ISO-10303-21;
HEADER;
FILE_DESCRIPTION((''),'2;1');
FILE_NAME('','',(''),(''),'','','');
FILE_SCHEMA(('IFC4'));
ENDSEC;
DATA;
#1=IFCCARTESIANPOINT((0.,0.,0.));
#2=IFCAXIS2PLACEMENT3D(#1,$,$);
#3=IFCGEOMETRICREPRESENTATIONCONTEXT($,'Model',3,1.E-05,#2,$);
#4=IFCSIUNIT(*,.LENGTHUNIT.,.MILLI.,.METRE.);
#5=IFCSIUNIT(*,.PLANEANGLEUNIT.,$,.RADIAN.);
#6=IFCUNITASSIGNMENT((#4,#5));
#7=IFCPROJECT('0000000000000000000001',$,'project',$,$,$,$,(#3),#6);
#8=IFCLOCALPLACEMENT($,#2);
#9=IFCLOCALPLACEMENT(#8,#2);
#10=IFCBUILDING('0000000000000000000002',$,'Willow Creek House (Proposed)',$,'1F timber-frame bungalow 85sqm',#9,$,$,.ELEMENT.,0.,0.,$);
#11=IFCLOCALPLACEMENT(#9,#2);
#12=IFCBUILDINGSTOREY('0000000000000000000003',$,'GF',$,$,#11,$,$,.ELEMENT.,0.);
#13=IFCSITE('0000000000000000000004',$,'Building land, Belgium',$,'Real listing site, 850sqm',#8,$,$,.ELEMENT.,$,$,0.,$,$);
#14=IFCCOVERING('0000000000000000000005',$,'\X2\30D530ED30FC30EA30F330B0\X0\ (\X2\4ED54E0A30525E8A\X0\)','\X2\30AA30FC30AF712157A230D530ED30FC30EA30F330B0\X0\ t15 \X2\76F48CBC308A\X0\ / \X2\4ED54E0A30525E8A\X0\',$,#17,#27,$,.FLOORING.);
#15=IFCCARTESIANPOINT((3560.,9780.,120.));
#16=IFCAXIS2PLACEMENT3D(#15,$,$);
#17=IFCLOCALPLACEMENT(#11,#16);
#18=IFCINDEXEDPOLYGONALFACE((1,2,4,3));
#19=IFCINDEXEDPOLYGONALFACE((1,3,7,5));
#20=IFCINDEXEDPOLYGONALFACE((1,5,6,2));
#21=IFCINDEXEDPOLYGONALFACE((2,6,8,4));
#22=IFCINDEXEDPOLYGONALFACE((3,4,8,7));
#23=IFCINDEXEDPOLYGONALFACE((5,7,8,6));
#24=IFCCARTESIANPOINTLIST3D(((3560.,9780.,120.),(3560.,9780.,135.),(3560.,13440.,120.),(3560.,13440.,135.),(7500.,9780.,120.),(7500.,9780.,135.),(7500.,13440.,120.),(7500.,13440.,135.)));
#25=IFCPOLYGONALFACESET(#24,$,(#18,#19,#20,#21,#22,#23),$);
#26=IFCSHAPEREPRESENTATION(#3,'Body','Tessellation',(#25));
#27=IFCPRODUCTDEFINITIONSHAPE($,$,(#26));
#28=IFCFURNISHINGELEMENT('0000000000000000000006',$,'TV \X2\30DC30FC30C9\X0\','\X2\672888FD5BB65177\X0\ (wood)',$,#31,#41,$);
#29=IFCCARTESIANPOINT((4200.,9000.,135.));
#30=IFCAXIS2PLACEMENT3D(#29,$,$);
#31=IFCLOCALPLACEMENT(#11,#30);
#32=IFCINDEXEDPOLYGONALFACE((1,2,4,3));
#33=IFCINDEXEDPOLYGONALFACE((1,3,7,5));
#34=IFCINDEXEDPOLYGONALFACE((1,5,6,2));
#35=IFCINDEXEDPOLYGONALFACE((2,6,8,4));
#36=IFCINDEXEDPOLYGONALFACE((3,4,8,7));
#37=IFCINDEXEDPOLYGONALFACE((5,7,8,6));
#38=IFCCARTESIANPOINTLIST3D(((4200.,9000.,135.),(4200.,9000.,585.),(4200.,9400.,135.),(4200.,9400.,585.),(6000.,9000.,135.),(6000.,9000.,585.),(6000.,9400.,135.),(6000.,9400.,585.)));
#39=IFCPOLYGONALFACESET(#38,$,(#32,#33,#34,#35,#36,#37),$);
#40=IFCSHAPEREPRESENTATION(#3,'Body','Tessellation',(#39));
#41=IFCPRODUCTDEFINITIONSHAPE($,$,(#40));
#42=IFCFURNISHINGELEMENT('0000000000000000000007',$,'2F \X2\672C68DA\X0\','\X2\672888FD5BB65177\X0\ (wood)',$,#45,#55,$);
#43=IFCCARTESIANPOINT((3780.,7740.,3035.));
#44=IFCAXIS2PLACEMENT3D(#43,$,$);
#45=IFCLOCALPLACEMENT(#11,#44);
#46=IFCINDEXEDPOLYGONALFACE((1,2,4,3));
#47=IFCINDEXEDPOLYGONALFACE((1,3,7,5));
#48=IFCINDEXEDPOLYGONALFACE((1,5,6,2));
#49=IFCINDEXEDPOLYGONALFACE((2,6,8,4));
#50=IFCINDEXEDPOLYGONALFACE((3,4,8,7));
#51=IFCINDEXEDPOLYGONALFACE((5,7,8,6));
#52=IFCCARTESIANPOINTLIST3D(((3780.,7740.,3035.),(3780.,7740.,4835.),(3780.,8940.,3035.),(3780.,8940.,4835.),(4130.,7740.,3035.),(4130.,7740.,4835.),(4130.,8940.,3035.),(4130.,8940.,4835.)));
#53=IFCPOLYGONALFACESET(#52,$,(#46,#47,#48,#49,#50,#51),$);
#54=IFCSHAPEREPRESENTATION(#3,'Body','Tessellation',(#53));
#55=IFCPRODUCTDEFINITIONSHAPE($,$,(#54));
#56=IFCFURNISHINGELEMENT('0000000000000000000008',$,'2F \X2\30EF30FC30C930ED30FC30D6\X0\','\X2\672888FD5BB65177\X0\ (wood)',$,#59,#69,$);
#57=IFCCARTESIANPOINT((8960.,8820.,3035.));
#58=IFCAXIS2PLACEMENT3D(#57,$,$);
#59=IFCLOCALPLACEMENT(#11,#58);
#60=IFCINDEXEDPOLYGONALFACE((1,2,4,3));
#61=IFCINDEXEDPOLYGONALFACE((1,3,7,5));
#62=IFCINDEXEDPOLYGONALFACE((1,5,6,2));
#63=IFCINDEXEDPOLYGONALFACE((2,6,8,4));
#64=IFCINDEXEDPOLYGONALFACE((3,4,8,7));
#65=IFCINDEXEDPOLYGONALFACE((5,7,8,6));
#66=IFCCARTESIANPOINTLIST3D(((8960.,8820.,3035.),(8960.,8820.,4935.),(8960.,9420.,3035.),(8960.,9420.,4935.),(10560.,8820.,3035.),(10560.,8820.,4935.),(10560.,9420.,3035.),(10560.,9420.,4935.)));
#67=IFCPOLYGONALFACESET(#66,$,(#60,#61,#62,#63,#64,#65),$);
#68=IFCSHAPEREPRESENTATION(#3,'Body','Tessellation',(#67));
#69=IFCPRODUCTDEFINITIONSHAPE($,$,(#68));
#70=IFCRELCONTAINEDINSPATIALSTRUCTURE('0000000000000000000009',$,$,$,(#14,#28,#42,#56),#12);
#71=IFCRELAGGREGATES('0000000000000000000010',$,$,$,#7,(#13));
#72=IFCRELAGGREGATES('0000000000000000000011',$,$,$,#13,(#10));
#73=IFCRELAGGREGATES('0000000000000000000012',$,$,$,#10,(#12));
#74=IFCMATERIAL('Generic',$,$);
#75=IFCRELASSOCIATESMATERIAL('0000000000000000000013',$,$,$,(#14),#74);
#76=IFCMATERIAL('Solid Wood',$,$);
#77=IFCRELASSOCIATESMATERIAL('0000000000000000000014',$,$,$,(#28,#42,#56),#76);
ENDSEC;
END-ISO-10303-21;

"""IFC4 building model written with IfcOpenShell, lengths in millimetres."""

from ifc_helpers import new_model, si_unit, frame, frame_2d, origin, place, context, project, spatial, rectangle, extrude, material, element, save


model = new_model("IFC4")

# Units and contexts
model_context = context("Model", 3, precision=1e-05, world=origin())
ifc_project = project(units=[si_unit("LENGTHUNIT", "METRE", prefix="MILLI"), si_unit("PLANEANGLEUNIT", "RADIAN")], contexts=[model_context])

# Site, building, storey
site_placement = place(None, origin())
site = spatial("IfcSite", under=ifc_project, at=site_placement, Name="Building land, Belgium", ObjectType="Real listing site, 850sqm", CompositionType="ELEMENT", RefElevation=0.0)
building_placement = place(site_placement, origin())
building = spatial("IfcBuilding", under=site, at=building_placement, Name="Willow Creek House (Proposed)", ObjectType="1F timber-frame bungalow 85sqm", CompositionType="ELEMENT", ElevationOfRefHeight=0.0, ElevationOfTerrain=0.0)
storey_placement = place(building_placement, origin())
storey = spatial("IfcBuildingStorey", under=building, at=storey_placement, Name="GF", CompositionType="ELEMENT", Elevation=0.0)

# Shared definitions
ifc_material_1 = material(Name="Solid Wood")

# Shared definitions
ifc_material_2 = material(Name="Generic")

# Covering
covering_placement = place(storey_placement, frame((3560.0, 9780.0, 120.0)))
element("IfcCovering", 1, at=covering_placement, inside=storey, material=ifc_material_2, Name="フローリング (仕上げ床)", Description="オーク無垢フローリング t15 直貼り / 仕上げ床", PredefinedType="FLOORING", context=model_context, shape_type="SweptSolid", body=[
    extrude(rectangle(XDim=3940.0, YDim=3660.0, at=frame_2d((1970.0, 1830.0))), frame((3560.0, 9780.0, 120.0)), (0.0, 0.0, 1.0), 15.0),
])

# Furnishing elements
furnishing_1_placement = place(storey_placement, frame((4200.0, 9000.0, 135.0)))
element("IfcFurnishingElement", 2, at=furnishing_1_placement, inside=storey, material=ifc_material_1, Name="TV ボード", Description="木製家具 (wood)", context=model_context, shape_type="SweptSolid", body=[
    extrude(rectangle(XDim=1800.0, YDim=400.0, at=frame_2d((900.0, 200.0))), frame((4200.0, 9000.0, 135.0)), (0.0, 0.0, 1.0), 450.0),
])
furnishing_2_placement = place(storey_placement, frame((3780.0, 7740.0, 3035.0)))
element("IfcFurnishingElement", 3, at=furnishing_2_placement, inside=storey, material=ifc_material_1, Name="2F 本棚", Description="木製家具 (wood)", context=model_context, shape_type="SweptSolid", body=[
    extrude(rectangle(XDim=350.0, YDim=1200.0, at=frame_2d((175.0, 600.0))), frame((3780.0, 7740.0, 3035.0)), (0.0, 0.0, 1.0), 1800.0),
])
furnishing_3_placement = place(storey_placement, frame((8960.0, 8820.0, 3035.0)))
element("IfcFurnishingElement", 4, at=furnishing_3_placement, inside=storey, material=ifc_material_1, Name="2F ワードローブ", Description="木製家具 (wood)", context=model_context, shape_type="SweptSolid", body=[
    extrude(rectangle(XDim=1600.0, YDim=600.0, at=frame_2d((800.0, 300.0))), frame((8960.0, 8820.0, 3035.0)), (0.0, 0.0, 1.0), 1900.0),
])

save(model, "model.ifc")
